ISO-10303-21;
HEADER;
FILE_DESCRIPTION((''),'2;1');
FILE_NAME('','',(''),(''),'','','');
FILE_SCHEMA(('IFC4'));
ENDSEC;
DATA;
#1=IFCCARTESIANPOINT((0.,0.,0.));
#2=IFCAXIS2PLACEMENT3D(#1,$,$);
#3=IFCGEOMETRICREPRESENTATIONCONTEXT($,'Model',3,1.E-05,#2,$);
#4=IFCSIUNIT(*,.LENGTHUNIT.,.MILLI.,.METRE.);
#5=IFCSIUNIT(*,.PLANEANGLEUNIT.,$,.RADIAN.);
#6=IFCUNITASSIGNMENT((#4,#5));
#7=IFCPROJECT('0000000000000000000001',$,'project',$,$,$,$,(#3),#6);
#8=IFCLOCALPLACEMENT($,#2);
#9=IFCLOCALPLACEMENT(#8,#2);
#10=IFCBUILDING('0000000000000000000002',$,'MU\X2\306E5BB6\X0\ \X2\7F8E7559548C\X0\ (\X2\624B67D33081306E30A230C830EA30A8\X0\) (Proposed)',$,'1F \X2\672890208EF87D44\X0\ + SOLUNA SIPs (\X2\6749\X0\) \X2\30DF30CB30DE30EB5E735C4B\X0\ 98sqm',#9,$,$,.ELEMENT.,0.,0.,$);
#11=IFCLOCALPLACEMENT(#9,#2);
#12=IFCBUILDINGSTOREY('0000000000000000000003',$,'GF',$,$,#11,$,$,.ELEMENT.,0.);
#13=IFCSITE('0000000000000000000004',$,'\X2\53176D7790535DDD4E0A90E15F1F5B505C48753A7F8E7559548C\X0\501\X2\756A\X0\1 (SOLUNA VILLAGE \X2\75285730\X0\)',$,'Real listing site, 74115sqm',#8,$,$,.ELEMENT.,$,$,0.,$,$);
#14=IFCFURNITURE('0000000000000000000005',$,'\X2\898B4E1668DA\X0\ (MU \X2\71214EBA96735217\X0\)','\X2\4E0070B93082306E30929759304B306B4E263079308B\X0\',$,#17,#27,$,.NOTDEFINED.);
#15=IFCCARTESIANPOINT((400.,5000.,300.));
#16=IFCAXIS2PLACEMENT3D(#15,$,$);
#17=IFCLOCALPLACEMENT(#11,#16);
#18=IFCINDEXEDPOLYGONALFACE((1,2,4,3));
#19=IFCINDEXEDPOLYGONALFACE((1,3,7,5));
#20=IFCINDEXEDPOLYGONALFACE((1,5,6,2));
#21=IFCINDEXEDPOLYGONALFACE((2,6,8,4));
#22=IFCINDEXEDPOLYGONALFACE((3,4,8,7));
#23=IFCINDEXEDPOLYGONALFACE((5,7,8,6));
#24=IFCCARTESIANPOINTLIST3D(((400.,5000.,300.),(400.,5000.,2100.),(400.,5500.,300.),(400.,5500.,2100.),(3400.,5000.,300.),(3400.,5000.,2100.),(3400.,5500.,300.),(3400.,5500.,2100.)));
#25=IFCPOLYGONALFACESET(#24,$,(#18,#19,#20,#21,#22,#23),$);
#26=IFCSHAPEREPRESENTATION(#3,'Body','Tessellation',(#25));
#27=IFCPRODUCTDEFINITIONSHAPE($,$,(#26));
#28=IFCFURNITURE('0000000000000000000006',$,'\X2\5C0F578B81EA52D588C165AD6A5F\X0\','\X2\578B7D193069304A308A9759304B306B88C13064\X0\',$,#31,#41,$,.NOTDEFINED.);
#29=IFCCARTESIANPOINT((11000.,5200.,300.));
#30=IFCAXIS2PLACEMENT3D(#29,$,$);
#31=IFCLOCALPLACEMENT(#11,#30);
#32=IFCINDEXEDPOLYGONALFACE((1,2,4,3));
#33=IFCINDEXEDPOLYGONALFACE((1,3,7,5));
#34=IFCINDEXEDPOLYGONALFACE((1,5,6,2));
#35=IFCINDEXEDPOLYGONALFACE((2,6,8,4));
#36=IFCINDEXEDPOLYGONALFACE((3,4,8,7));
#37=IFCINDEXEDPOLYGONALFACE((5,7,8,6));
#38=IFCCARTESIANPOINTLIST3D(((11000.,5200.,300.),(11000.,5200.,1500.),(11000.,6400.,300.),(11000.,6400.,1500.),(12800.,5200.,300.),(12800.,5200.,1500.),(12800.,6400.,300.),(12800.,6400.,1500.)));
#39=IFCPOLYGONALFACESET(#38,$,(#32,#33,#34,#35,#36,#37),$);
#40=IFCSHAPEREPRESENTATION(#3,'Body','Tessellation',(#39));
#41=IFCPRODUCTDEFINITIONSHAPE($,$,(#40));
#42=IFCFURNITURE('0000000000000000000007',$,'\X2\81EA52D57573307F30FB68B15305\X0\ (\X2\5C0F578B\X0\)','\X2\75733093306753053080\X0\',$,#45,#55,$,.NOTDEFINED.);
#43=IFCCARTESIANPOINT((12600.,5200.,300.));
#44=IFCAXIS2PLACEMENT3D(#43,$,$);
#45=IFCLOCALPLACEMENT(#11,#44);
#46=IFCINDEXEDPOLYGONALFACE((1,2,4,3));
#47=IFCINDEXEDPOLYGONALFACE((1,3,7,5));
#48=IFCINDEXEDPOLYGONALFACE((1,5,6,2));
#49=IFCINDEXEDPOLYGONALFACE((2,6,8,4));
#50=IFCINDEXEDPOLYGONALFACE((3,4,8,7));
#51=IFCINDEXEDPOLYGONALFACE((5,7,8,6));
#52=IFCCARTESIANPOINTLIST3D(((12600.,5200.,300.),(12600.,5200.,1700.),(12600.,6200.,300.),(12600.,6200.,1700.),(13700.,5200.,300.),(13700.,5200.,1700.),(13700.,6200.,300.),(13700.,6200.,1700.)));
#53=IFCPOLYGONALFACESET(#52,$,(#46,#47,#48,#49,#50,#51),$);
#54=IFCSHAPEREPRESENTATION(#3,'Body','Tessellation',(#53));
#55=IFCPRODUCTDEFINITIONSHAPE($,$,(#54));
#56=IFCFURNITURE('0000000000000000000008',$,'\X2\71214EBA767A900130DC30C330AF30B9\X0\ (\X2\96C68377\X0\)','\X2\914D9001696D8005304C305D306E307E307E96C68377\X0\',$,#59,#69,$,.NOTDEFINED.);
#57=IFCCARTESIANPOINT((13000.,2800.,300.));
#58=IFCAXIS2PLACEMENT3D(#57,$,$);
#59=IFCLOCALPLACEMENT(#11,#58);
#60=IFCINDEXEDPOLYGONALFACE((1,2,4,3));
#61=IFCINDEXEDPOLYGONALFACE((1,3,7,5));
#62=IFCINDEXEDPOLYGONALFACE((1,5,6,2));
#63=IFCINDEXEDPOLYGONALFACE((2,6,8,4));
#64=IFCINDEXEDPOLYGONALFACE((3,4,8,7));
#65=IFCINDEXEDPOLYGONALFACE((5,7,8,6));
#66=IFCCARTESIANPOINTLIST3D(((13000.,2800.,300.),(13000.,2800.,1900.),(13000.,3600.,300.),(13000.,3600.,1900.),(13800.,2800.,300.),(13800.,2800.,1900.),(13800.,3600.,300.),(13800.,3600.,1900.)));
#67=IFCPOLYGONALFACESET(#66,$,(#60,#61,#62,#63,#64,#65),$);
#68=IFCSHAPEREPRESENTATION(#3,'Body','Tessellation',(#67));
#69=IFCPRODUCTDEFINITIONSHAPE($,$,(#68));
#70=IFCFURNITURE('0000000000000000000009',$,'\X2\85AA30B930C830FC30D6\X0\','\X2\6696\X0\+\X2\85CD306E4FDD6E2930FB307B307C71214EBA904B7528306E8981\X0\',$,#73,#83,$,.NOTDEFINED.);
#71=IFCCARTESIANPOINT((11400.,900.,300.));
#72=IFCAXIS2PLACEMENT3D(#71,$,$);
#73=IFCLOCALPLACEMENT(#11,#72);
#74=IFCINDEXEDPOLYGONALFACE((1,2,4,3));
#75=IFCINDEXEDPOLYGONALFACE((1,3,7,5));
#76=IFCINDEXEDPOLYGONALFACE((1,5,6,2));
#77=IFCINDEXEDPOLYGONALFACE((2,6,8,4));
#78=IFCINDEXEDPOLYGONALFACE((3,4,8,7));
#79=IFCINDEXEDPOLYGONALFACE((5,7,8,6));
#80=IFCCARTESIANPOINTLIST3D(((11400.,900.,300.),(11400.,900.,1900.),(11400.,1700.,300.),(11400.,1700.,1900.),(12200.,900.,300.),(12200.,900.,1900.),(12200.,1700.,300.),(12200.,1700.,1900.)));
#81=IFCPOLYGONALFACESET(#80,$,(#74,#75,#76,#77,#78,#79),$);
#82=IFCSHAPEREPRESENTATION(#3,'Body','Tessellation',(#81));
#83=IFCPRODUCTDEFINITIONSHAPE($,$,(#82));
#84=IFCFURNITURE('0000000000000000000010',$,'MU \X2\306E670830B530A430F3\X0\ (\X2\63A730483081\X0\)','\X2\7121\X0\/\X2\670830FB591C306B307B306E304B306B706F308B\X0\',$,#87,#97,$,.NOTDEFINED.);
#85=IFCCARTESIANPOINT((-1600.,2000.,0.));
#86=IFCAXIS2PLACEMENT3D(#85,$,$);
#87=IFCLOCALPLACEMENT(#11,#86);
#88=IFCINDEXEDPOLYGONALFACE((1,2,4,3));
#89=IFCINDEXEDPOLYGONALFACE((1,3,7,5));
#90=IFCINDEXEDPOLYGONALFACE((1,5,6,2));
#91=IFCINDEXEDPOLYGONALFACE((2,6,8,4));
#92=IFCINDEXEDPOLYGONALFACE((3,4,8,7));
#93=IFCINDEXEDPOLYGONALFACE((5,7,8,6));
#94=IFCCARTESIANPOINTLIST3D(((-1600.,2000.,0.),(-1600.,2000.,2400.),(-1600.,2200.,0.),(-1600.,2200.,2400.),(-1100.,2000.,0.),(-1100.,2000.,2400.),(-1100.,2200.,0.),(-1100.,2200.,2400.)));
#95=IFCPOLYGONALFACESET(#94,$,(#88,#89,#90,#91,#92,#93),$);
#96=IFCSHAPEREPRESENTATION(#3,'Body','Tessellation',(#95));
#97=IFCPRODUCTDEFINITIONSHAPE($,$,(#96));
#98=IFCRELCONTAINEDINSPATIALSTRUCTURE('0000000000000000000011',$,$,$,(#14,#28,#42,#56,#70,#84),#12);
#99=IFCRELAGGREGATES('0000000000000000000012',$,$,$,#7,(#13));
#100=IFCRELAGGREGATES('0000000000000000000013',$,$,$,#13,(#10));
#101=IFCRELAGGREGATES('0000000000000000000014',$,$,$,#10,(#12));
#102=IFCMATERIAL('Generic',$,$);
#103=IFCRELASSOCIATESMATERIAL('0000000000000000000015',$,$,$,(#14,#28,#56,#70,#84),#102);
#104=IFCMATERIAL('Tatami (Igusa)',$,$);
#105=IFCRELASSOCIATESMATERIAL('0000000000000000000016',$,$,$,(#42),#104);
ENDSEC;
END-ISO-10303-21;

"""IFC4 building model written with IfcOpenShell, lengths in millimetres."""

from ifc_helpers import new_model, si_unit, frame, frame_2d, origin, place, context, project, spatial, rectangle, extrude, material, element, save


model = new_model("IFC4")

# Units and contexts
model_context = context("Model", 3, precision=1e-05, world=origin())
ifc_project = project(units=[si_unit("LENGTHUNIT", "METRE", prefix="MILLI"), si_unit("PLANEANGLEUNIT", "RADIAN")], contexts=[model_context])

# Site, building, storey
site_placement = place(None, origin())
site = spatial("IfcSite", under=ifc_project, at=site_placement, Name="北海道川上郡弟子屈町美留和501番1 (SOLUNA VILLAGE 用地)", ObjectType="Real listing site, 74115sqm", CompositionType="ELEMENT", RefElevation=0.0)
building_placement = place(site_placement, origin())
building = spatial("IfcBuilding", under=site, at=building_placement, Name="MUの家 美留和 (手染めのアトリエ) (Proposed)", ObjectType="1F 木造軸組 + SOLUNA SIPs (杉) ミニマル平屋 98sqm", CompositionType="ELEMENT", ElevationOfRefHeight=0.0, ElevationOfTerrain=0.0)
storey_placement = place(building_placement, origin())
storey = spatial("IfcBuildingStorey", under=building, at=storey_placement, Name="GF", CompositionType="ELEMENT", Elevation=0.0)

# Shared definitions
ifc_material_1 = material(Name="Generic")

# Furniture
furniture_1_placement = place(storey_placement, frame((400.0, 5000.0, 300.0)))
element("IfcFurniture", 1, at=furniture_1_placement, inside=storey, material=ifc_material_1, Name="見世棚 (MU 無人陳列)", Description="一点ものを静かに並べる", PredefinedType="NOTDEFINED", context=model_context, shape_type="SweptSolid", body=[
    extrude(rectangle(XDim=3000.0, YDim=500.0, at=frame_2d((1500.0, 250.0))), frame((400.0, 5000.0, 300.0)), (0.0, 0.0, 1.0), 1800.0),
])
furniture_2_placement = place(storey_placement, frame((11000.0, 5200.0, 300.0)))
element("IfcFurniture", 2, at=furniture_2_placement, inside=storey, material=ifc_material_1, Name="小型自動裁断機", Description="型紙どおり静かに裁つ", PredefinedType="NOTDEFINED", context=model_context, shape_type="SweptSolid", body=[
    extrude(rectangle(XDim=1800.0, YDim=1200.0, at=frame_2d((900.0, 600.0))), frame((11000.0, 5200.0, 300.0)), (0.0, 0.0, 1.0), 1200.0),
])
ifc_material_2 = material(Name="Tatami (Igusa)")
furniture_3_placement = place(storey_placement, frame((12600.0, 5200.0, 300.0)))
element("IfcFurniture", 3, at=furniture_3_placement, inside=storey, material=ifc_material_2, Name="自動畳み・梱包 (小型)", Description="畳んで包む", PredefinedType="NOTDEFINED", context=model_context, shape_type="SweptSolid", body=[
    extrude(rectangle(XDim=1100.0, YDim=1000.0, at=frame_2d((550.0, 500.0))), frame((12600.0, 5200.0, 300.0)), (0.0, 0.0, 1.0), 1400.0),
])
furniture_4_placement = place(storey_placement, frame((13000.0, 2800.0, 300.0)))
element("IfcFurniture", 4, at=furniture_4_placement, inside=storey, material=ifc_material_1, Name="無人発送ボックス (集荷)", Description="配送業者がそのまま集荷", PredefinedType="NOTDEFINED", context=model_context, shape_type="SweptSolid", body=[
    extrude(rectangle(XDim=800.0, YDim=800.0, at=frame_2d((400.0, 400.0))), frame((13000.0, 2800.0, 300.0)), (0.0, 0.0, 1.0), 1600.0),
])
furniture_5_placement = place(storey_placement, frame((11400.0, 900.0, 300.0)))
element("IfcFurniture", 5, at=furniture_5_placement, inside=storey, material=ifc_material_1, Name="薪ストーブ", Description="暖+藍の保温・ほぼ無人運用の要", PredefinedType="NOTDEFINED", context=model_context, shape_type="SweptSolid", body=[
    extrude(rectangle(XDim=800.0, YDim=800.0, at=frame_2d((400.0, 400.0))), frame((11400.0, 900.0, 300.0)), (0.0, 0.0, 1.0), 1600.0),
])
furniture_6_placement = place(storey_placement, frame((-1600.0, 2000.0, 0.0)))
element("IfcFurniture", 6, at=furniture_6_placement, inside=storey, material=ifc_material_1, Name="MU の月サイン (控えめ)", Description="無/月・夜にほのかに灯る", PredefinedType="NOTDEFINED", context=model_context, shape_type="SweptSolid", body=[
    extrude(rectangle(XDim=500.0, YDim=200.0, at=frame_2d((250.0, 100.0))), frame((-1600.0, 2000.0, 0.0)), (0.0, 0.0, 1.0), 2400.0),
])

save(model, "model.ifc")
